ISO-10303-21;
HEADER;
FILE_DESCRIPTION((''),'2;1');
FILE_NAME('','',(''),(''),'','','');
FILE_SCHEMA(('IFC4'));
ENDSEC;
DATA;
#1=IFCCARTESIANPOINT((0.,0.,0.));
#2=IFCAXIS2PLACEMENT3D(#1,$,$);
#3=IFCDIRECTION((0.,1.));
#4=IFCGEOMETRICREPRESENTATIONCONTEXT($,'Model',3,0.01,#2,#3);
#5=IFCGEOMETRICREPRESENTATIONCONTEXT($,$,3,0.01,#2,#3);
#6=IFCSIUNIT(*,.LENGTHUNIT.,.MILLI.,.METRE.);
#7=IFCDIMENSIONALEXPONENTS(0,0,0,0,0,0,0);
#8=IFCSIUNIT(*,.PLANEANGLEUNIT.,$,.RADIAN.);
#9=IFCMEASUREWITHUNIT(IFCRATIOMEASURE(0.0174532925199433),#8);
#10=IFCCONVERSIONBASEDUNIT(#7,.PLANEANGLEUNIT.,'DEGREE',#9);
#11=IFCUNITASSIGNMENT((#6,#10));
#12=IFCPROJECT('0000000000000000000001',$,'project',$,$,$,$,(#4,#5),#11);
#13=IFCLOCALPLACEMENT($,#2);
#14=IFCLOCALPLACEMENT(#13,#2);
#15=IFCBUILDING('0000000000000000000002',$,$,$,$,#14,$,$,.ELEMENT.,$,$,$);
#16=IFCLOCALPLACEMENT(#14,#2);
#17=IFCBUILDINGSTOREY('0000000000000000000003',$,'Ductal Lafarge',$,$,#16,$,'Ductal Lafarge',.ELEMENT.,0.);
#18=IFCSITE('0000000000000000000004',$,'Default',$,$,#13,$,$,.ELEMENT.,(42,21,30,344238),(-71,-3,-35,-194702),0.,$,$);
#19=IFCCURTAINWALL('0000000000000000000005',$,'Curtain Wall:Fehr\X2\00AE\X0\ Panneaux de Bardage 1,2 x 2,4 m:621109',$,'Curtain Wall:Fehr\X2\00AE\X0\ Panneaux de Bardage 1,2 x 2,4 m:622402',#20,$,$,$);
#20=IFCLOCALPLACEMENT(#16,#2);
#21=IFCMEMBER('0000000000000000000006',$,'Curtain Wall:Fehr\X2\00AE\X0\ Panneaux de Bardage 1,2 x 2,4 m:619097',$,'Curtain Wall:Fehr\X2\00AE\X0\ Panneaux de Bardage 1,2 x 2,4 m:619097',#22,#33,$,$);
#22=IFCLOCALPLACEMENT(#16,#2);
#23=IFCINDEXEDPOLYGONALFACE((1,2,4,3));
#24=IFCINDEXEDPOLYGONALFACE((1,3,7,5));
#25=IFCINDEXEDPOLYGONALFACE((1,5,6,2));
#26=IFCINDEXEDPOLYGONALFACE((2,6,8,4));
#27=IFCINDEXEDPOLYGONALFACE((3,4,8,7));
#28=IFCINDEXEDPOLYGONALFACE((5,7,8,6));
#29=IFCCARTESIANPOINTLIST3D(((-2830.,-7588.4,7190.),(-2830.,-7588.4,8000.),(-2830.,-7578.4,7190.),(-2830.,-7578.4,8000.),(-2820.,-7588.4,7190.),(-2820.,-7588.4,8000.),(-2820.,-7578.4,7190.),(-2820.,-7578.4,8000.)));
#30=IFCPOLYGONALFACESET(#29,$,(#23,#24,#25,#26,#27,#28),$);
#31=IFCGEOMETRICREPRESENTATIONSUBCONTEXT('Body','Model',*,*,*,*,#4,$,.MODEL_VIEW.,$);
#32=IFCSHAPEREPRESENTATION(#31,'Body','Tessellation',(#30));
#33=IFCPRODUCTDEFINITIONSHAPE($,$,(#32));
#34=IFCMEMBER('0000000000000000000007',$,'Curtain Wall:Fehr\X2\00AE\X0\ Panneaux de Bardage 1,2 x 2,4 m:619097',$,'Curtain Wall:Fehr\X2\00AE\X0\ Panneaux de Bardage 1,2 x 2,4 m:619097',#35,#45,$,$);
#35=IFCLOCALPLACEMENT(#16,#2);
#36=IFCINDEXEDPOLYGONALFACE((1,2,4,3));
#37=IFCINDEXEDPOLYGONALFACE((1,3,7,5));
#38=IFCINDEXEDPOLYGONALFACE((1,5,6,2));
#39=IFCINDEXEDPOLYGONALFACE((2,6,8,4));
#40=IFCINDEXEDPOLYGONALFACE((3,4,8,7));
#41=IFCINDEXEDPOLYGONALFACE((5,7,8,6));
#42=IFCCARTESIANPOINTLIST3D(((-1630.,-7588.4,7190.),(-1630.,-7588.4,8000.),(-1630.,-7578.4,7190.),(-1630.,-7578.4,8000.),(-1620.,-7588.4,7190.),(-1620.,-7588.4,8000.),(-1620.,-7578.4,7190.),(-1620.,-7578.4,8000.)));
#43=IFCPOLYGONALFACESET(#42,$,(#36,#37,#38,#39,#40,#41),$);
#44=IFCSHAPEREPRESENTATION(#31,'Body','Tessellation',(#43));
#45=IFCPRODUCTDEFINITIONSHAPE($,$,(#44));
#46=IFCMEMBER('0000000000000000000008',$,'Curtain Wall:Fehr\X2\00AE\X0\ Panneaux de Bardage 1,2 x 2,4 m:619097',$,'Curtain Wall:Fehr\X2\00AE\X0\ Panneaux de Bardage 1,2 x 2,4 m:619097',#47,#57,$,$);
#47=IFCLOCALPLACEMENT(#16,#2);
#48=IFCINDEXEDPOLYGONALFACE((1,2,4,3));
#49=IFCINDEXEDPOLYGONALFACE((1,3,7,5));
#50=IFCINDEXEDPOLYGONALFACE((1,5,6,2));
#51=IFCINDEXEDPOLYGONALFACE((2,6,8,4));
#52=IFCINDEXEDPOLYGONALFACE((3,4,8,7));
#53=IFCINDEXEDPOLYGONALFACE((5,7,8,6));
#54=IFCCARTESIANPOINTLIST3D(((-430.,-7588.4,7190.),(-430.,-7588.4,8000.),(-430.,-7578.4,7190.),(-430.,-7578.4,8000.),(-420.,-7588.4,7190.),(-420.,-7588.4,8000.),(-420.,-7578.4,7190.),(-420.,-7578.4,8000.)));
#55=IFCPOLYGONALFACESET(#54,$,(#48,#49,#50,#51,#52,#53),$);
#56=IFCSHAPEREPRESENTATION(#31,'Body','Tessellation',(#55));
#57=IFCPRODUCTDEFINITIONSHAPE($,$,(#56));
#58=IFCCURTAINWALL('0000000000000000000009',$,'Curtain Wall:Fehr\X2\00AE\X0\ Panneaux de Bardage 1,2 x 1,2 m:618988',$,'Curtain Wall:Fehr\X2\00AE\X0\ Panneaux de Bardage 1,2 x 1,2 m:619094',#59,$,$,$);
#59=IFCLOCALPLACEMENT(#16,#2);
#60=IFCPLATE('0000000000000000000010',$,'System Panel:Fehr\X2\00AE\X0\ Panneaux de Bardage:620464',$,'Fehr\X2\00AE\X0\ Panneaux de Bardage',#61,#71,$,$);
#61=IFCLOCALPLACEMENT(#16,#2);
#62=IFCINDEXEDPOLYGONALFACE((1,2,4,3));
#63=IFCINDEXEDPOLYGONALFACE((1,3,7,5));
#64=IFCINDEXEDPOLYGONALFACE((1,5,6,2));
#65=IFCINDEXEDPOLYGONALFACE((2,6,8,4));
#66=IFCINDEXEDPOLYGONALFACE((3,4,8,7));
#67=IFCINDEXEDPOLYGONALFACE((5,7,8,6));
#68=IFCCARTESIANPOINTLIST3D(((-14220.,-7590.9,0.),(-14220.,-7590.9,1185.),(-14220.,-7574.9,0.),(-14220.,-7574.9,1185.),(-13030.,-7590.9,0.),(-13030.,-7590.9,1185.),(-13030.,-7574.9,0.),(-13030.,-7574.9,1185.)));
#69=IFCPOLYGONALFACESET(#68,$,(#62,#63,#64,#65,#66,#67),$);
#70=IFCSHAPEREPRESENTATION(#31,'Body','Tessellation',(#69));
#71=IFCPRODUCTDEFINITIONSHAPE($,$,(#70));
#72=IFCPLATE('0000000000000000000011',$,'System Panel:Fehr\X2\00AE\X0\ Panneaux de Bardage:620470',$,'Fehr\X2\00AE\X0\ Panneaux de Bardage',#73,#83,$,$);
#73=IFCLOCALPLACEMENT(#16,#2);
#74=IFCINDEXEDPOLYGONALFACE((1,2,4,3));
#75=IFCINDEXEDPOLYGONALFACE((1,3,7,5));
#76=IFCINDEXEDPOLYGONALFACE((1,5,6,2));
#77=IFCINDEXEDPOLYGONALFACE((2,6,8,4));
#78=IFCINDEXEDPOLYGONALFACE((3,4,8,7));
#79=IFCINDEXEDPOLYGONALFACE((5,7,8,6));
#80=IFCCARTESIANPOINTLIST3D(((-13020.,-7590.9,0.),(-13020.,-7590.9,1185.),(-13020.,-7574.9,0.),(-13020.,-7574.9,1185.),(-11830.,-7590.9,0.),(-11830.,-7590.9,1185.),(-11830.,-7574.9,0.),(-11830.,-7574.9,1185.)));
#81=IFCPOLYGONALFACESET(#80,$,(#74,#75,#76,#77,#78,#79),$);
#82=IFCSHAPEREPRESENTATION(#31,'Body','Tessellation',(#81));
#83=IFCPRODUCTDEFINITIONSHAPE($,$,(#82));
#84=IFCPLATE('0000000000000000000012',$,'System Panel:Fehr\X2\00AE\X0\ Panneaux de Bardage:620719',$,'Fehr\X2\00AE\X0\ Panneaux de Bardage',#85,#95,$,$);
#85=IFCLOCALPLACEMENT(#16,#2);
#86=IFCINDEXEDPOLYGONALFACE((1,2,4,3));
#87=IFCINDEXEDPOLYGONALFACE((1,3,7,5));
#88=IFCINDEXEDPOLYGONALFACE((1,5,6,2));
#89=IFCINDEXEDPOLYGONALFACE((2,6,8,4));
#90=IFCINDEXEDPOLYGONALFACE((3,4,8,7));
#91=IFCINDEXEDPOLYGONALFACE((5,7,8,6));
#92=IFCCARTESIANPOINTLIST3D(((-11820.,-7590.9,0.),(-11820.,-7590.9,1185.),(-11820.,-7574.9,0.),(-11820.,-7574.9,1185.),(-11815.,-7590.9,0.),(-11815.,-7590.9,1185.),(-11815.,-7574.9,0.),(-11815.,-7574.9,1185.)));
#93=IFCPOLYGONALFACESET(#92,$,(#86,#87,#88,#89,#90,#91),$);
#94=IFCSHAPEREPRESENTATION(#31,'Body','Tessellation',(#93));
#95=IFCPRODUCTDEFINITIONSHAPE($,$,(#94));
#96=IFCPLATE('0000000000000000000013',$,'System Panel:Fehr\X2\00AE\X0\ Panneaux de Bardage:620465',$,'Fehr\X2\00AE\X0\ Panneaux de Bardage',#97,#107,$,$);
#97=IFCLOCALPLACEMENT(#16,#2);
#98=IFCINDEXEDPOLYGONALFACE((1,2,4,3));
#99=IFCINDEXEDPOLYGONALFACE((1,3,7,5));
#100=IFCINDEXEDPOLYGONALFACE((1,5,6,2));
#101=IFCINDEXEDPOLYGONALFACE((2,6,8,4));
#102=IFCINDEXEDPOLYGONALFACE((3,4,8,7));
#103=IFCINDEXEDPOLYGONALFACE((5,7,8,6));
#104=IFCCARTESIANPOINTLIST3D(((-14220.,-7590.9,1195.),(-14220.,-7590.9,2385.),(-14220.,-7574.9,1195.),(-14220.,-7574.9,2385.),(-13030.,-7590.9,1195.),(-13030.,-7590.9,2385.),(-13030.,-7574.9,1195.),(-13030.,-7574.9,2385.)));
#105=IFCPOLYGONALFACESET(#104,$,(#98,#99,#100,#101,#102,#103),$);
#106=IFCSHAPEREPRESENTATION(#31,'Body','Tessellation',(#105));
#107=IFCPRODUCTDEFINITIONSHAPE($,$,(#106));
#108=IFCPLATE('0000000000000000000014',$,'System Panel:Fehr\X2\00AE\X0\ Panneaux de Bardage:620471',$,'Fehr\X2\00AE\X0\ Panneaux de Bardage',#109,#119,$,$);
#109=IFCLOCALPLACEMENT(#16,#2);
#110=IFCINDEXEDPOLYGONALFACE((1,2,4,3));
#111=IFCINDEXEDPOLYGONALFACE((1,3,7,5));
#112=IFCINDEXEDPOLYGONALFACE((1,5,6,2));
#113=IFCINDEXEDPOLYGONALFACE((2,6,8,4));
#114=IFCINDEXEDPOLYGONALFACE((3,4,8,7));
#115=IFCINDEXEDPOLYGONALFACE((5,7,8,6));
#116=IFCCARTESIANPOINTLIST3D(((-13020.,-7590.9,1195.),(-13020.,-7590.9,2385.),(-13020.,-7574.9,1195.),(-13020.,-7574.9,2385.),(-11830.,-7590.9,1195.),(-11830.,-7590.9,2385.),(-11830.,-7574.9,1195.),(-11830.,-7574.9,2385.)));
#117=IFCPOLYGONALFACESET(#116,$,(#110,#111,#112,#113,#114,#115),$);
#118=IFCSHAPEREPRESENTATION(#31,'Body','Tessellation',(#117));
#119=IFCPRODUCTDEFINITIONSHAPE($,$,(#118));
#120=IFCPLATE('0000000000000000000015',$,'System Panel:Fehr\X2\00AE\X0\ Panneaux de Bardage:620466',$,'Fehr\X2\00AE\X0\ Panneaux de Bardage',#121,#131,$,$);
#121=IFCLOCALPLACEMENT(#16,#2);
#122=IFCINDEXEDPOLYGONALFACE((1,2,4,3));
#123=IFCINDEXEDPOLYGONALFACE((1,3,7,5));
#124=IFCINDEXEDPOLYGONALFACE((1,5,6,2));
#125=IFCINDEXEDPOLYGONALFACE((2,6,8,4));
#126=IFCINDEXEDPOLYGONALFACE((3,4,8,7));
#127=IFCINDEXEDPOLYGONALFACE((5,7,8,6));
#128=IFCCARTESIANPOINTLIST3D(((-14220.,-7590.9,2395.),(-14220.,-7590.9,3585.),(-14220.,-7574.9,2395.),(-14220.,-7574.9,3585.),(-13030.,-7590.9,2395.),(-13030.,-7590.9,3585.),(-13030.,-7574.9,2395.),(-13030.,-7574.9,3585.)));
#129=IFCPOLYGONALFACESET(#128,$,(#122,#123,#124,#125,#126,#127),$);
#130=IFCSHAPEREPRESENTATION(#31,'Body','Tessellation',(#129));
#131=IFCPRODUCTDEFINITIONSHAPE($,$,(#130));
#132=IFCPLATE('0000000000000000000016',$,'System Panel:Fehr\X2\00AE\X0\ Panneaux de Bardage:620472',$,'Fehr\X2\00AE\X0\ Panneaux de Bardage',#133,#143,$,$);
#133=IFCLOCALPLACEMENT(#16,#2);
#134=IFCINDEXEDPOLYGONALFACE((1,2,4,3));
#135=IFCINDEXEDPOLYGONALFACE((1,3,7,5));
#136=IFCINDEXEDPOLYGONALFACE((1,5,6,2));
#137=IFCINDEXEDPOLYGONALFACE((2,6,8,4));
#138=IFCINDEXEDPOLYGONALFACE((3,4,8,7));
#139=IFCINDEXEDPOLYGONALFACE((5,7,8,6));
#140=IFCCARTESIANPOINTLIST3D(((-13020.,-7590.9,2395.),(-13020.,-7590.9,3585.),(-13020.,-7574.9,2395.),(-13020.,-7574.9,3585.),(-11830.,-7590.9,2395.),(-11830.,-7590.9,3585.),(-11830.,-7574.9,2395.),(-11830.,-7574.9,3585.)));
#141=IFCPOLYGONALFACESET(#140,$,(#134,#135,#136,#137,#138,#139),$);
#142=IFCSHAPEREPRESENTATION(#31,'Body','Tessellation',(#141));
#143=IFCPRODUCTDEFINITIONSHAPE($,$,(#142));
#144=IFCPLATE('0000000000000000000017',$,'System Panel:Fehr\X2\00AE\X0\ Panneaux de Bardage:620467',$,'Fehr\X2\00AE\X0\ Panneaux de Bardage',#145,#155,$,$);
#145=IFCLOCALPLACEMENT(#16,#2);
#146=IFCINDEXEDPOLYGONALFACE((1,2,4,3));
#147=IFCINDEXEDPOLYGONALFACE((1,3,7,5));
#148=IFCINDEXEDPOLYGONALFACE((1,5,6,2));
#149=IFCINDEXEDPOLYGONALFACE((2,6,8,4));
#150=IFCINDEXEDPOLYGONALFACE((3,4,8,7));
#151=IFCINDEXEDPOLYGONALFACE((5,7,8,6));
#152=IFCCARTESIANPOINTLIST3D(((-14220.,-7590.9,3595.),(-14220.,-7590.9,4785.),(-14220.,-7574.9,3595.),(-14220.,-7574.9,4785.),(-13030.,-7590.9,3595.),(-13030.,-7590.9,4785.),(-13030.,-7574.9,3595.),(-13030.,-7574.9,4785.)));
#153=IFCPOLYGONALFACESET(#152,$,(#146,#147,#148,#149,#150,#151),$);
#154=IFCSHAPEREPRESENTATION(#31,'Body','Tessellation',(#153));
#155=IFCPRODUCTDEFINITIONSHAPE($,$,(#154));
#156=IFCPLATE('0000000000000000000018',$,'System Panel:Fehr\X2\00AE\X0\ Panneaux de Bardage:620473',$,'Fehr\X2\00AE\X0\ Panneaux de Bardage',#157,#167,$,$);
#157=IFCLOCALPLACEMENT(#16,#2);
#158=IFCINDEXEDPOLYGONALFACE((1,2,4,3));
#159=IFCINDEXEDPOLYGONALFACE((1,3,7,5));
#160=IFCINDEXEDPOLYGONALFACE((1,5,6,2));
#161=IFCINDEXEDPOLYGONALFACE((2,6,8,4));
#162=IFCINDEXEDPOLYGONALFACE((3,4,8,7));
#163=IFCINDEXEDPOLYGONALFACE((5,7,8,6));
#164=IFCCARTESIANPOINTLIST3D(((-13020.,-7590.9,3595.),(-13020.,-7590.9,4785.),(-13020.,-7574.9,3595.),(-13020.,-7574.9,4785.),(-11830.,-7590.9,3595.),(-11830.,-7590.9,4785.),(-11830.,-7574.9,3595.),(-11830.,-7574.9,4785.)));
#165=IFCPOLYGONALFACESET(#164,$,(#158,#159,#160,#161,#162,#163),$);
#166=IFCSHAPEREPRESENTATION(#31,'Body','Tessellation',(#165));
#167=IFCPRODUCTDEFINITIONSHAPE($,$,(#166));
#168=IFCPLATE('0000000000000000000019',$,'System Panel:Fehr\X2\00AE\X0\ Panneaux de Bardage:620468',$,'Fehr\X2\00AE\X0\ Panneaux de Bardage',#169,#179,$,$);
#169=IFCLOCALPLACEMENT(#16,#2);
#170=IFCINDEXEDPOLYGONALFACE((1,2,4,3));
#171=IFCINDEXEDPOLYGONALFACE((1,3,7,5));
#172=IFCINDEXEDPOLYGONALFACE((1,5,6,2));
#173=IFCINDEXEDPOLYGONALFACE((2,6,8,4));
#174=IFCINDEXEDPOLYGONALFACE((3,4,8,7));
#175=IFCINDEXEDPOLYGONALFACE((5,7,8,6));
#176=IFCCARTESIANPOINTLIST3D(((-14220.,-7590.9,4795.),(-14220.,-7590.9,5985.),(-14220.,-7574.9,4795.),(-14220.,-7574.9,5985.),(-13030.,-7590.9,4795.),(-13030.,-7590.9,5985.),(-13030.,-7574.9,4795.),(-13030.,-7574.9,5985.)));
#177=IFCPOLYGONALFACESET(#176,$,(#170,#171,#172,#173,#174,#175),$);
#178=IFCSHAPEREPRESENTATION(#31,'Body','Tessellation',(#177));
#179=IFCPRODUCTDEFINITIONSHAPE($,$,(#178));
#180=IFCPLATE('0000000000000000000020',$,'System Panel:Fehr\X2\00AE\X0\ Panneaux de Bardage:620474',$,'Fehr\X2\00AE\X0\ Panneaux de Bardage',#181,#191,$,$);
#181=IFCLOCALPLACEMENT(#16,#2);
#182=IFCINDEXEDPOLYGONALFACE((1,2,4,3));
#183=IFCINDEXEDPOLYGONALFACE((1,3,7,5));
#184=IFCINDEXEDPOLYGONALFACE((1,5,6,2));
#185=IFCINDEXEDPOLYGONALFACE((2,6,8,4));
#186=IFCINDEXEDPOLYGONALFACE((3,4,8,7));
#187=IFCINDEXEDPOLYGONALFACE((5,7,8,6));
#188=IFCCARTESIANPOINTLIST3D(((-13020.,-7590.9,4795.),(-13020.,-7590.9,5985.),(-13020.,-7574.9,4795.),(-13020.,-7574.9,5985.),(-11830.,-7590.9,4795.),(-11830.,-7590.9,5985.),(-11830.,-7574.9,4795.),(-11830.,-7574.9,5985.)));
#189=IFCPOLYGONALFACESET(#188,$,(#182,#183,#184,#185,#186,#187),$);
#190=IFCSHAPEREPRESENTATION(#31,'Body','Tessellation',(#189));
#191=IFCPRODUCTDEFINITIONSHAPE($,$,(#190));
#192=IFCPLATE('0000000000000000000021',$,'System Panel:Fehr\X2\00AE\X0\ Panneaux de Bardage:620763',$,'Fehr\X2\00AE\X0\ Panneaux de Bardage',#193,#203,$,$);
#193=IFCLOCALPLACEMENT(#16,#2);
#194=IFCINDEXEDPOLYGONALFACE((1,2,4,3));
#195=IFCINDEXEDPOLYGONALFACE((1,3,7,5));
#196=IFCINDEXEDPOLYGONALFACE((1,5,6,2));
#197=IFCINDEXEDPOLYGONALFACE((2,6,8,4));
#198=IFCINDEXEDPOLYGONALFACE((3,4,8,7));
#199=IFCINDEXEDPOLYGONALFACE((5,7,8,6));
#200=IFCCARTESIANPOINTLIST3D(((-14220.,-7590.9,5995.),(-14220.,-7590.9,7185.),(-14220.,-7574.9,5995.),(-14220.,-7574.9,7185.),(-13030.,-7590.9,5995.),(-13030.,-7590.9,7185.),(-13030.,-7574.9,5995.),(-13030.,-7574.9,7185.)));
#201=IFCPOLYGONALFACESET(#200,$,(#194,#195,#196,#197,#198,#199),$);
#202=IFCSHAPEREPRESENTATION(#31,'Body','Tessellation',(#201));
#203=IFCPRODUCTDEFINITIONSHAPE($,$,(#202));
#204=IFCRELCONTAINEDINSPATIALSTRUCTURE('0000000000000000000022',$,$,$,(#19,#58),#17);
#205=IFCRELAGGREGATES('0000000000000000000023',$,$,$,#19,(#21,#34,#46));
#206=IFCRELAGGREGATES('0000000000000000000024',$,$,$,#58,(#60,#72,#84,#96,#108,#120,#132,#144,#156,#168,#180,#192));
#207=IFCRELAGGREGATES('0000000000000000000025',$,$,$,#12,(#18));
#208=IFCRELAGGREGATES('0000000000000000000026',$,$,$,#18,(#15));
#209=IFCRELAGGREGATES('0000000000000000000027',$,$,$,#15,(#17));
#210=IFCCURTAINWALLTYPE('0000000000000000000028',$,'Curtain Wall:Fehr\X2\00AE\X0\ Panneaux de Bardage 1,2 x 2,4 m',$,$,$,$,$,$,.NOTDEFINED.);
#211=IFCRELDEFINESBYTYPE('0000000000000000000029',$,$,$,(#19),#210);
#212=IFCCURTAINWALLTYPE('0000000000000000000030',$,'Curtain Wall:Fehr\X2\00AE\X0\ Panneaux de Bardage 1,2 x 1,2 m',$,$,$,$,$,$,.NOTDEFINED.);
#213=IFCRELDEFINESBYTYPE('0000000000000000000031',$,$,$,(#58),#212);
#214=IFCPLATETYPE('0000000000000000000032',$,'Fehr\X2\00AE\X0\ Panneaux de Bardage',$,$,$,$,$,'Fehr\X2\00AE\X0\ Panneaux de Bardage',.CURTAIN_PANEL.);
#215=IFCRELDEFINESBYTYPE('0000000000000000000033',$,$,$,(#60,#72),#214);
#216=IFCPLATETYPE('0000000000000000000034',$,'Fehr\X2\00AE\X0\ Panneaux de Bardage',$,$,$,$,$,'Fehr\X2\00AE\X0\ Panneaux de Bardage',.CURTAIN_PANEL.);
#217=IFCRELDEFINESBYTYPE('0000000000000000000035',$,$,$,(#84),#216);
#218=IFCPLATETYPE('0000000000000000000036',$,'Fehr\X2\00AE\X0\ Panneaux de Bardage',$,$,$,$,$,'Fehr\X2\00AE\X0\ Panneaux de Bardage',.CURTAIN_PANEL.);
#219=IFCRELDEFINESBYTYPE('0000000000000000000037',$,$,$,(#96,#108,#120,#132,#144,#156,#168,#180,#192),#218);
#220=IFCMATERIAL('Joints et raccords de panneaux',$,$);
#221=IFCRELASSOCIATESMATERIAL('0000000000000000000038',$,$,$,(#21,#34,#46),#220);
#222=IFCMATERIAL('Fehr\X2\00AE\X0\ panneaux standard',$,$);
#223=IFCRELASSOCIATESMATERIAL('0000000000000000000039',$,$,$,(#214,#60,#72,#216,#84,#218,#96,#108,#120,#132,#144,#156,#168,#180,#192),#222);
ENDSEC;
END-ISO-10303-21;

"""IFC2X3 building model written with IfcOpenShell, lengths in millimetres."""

from ifc_helpers import new_model, entity, si_unit, converted_unit, direction, frame, frame_2d, origin, origin_2d_with_axis, place, context, subcontext, project, spatial, rectangle, extrude, source, transform, mapped, material, type_object, type_shapes, element, aggregate, save


model = new_model("IFC2X3")

# Units and contexts
model_context = context("Model", 3, precision=0.01, world=origin(), true_north=direction((0.0, 1.0)))
context_of_model = context(None, 3, precision=0.01, world=origin(), true_north=direction((0.0, 1.0)))
body_context = subcontext(model_context, "Body", "Model", "MODEL_VIEW")
ifc_project = project(units=[si_unit("LENGTHUNIT", "METRE", prefix="MILLI"), converted_unit("PLANEANGLEUNIT", "DEGREE", entity("IfcRatioMeasure", 0.0174532925199433), si_unit("PLANEANGLEUNIT", "RADIAN"), dimensions=[0, 0, 0, 0, 0, 0, 0])], contexts=[model_context, context_of_model])

# Site, building, storey
site_placement = place(None, origin())
site = spatial("IfcSite", under=ifc_project, at=site_placement, Name="Default", CompositionType="ELEMENT", RefLatitude=(42, 21, 30, 344238), RefLongitude=(-71, -3, -35, -194702), RefElevation=0.0)
building_placement = place(site_placement, origin())
building = spatial("IfcBuilding", under=site, at=building_placement, CompositionType="ELEMENT")
storey_placement = place(building_placement, origin())
storey = spatial("IfcBuildingStorey", under=building, at=storey_placement, Name="Ductal Lafarge", LongName="Ductal Lafarge", CompositionType="ELEMENT", Elevation=0.0)

# Curtain wall, members
curtain_wall_type_1 = type_object("IfcCurtainWallType", Name="Curtain Wall:Fehr® Panneaux de Bardage 1,2 x 2,4 m", PredefinedType="NOTDEFINED")
curtain_wall_1_placement = place(storey_placement, origin())
curtain_wall_1 = element("IfcCurtainWall", 1, at=curtain_wall_1_placement, inside=storey, type_object=curtain_wall_type_1, Name="Curtain Wall:Fehr® Panneaux de Bardage 1,2 x 2,4 m:621109", ObjectType="Curtain Wall:Fehr® Panneaux de Bardage 1,2 x 2,4 m:622402")
ifc_material_1 = material(Name="Joints et raccords de panneaux")
member_1_placement = place(curtain_wall_1_placement, frame((-2830.0, -7588.4, 7190.0)))
member_1 = element("IfcMember", 2, at=member_1_placement, material=ifc_material_1, Name="Curtain Wall:Fehr® Panneaux de Bardage 1,2 x 2,4 m:619097", ObjectType="Curtain Wall:Fehr® Panneaux de Bardage 1,2 x 2,4 m:619097", context=body_context, shape_type="SweptSolid", body=[
    extrude(rectangle(XDim=10.0, YDim=10.0, at=origin_2d_with_axis()), frame((5.0, 5.0, 0.0), z_axis=(0.0, 0.0, 1.0), x_axis=(0.0, 1.0, 0.0)), (0.0, 0.0, 1.0), 810.0),
])
member_2_placement = place(curtain_wall_1_placement, frame((-1630.0, -7588.4, 7190.0)))
member_2 = element("IfcMember", 3, at=member_2_placement, material=ifc_material_1, Name="Curtain Wall:Fehr® Panneaux de Bardage 1,2 x 2,4 m:619097", ObjectType="Curtain Wall:Fehr® Panneaux de Bardage 1,2 x 2,4 m:619097", context=body_context, shape_type="SweptSolid", body=[
    extrude(rectangle(XDim=10.0, YDim=10.0, at=origin_2d_with_axis()), frame((5.0, 5.0, 0.0), z_axis=(0.0, 0.0, 1.0), x_axis=(0.0, 1.0, 0.0)), (0.0, 0.0, 1.0), 810.0),
])
member_3_placement = place(curtain_wall_1_placement, frame((-430.0, -7588.4, 7190.0)))
member_3 = element("IfcMember", 4, at=member_3_placement, material=ifc_material_1, Name="Curtain Wall:Fehr® Panneaux de Bardage 1,2 x 2,4 m:619097", ObjectType="Curtain Wall:Fehr® Panneaux de Bardage 1,2 x 2,4 m:619097", context=body_context, shape_type="SweptSolid", body=[
    extrude(rectangle(XDim=10.0, YDim=10.0, at=frame_2d((0.0, 0.0), x_axis=(1.0, 0.0))), frame((5.0, 5.0, 0.0), z_axis=(0.0, 0.0, 1.0), x_axis=(0.0, 1.0, 0.0)), (0.0, 0.0, 1.0), 810.0),
])
aggregate(curtain_wall_1, [member_1, member_2, member_3])

# Curtain wall, plates
curtain_wall_type_2 = type_object("IfcCurtainWallType", Name="Curtain Wall:Fehr® Panneaux de Bardage 1,2 x 1,2 m", PredefinedType="NOTDEFINED")
curtain_wall_2_placement = place(storey_placement, origin())
curtain_wall_2 = element("IfcCurtainWall", 5, at=curtain_wall_2_placement, inside=storey, type_object=curtain_wall_type_2, Name="Curtain Wall:Fehr® Panneaux de Bardage 1,2 x 1,2 m:618988", ObjectType="Curtain Wall:Fehr® Panneaux de Bardage 1,2 x 1,2 m:619094")
ifc_material_2 = material(Name="Fehr® panneaux standard")
plate_type_1 = type_object("IfcPlateType", Name="Fehr® Panneaux de Bardage", ElementType="Fehr® Panneaux de Bardage", PredefinedType="CURTAIN_PANEL", material=ifc_material_2)
shared_shape_1 = source(origin(), body_context, "Body", "SweptSolid", [
    extrude(rectangle(XDim=16.0, YDim=1190.0, at=origin_2d_with_axis()), frame((0.0, 0.0, 0.0), z_axis=(0.0, 0.0, 1.0), x_axis=(0.0, 1.0, 0.0)), (0.0, 0.0, 1.0), 1185.0),
])
type_shapes(plate_type_1, [shared_shape_1])
plate_1_placement = place(curtain_wall_2_placement, frame((-13625.0, -7582.9, 0.0)))
plate_1 = element("IfcPlate", 6, at=plate_1_placement, type_object=plate_type_1, material=ifc_material_2, Name="System Panel:Fehr® Panneaux de Bardage:620464", ObjectType="Fehr® Panneaux de Bardage", context=body_context, shape_type="MappedRepresentation", body=[
    mapped(shared_shape_1, transform((0.0, 0.0, 0.0), scale=1.0)),
])
plate_2_placement = place(curtain_wall_2_placement, frame((-12425.0, -7582.9, 0.0)))
plate_2 = element("IfcPlate", 7, at=plate_2_placement, type_object=plate_type_1, material=ifc_material_2, Name="System Panel:Fehr® Panneaux de Bardage:620470", ObjectType="Fehr® Panneaux de Bardage", context=body_context, shape_type="MappedRepresentation", body=[
    mapped(shared_shape_1, transform((0.0, 0.0, 0.0), scale=1.0)),
])
plate_type_2 = type_object("IfcPlateType", Name="Fehr® Panneaux de Bardage", ElementType="Fehr® Panneaux de Bardage", PredefinedType="CURTAIN_PANEL", material=ifc_material_2)
shared_shape_2 = source(origin(), body_context, "Body", "SweptSolid", [
    extrude(rectangle(XDim=16.0, YDim=5.0, at=origin_2d_with_axis()), frame((0.0, 0.0, 0.0), z_axis=(0.0, 0.0, 1.0), x_axis=(0.0, 1.0, 0.0)), (0.0, 0.0, 1.0), 1185.0),
])
type_shapes(plate_type_2, [shared_shape_2])
plate_3_placement = place(curtain_wall_2_placement, frame((-11817.5, -7582.9, 0.0)))
plate_3 = element("IfcPlate", 8, at=plate_3_placement, type_object=plate_type_2, material=ifc_material_2, Name="System Panel:Fehr® Panneaux de Bardage:620719", ObjectType="Fehr® Panneaux de Bardage", context=body_context, shape_type="MappedRepresentation", body=[
    mapped(shared_shape_2, transform((0.0, 0.0, 0.0), scale=1.0)),
])
plate_type_3 = type_object("IfcPlateType", Name="Fehr® Panneaux de Bardage", ElementType="Fehr® Panneaux de Bardage", PredefinedType="CURTAIN_PANEL", material=ifc_material_2)
shared_shape_3 = source(origin(), body_context, "Body", "SweptSolid", [
    extrude(rectangle(XDim=16.0, YDim=1190.0, at=origin_2d_with_axis()), frame((0.0, 0.0, 0.0), z_axis=(0.0, 0.0, 1.0), x_axis=(0.0, 1.0, 0.0)), (0.0, 0.0, 1.0), 1190.0),
])
type_shapes(plate_type_3, [shared_shape_3])
plate_4_placement = place(curtain_wall_2_placement, frame((-13625.0, -7582.9, 1195.0)))
plate_4 = element("IfcPlate", 9, at=plate_4_placement, type_object=plate_type_3, material=ifc_material_2, Name="System Panel:Fehr® Panneaux de Bardage:620465", ObjectType="Fehr® Panneaux de Bardage", context=body_context, shape_type="MappedRepresentation", body=[
    mapped(shared_shape_3, transform((0.0, 0.0, 0.0), scale=1.0)),
])
plate_5_placement = place(curtain_wall_2_placement, frame((-12425.0, -7582.9, 1195.0)))
plate_5 = element("IfcPlate", 10, at=plate_5_placement, type_object=plate_type_3, material=ifc_material_2, Name="System Panel:Fehr® Panneaux de Bardage:620471", ObjectType="Fehr® Panneaux de Bardage", context=body_context, shape_type="MappedRepresentation", body=[
    mapped(shared_shape_3, transform((0.0, 0.0, 0.0), scale=1.0)),
])
plate_6_placement = place(curtain_wall_2_placement, frame((-13625.0, -7582.9, 2395.0)))
plate_6 = element("IfcPlate", 11, at=plate_6_placement, type_object=plate_type_3, material=ifc_material_2, Name="System Panel:Fehr® Panneaux de Bardage:620466", ObjectType="Fehr® Panneaux de Bardage", context=body_context, shape_type="MappedRepresentation", body=[
    mapped(shared_shape_3, transform((0.0, 0.0, 0.0), scale=1.0)),
])
plate_7_placement = place(curtain_wall_2_placement, frame((-12425.0, -7582.9, 2395.0)))
plate_7 = element("IfcPlate", 12, at=plate_7_placement, type_object=plate_type_3, material=ifc_material_2, Name="System Panel:Fehr® Panneaux de Bardage:620472", ObjectType="Fehr® Panneaux de Bardage", context=body_context, shape_type="MappedRepresentation", body=[
    mapped(shared_shape_3, transform((0.0, 0.0, 0.0), scale=1.0)),
])
plate_8_placement = place(curtain_wall_2_placement, frame((-13625.0, -7582.9, 3595.0)))
plate_8 = element("IfcPlate", 13, at=plate_8_placement, type_object=plate_type_3, material=ifc_material_2, Name="System Panel:Fehr® Panneaux de Bardage:620467", ObjectType="Fehr® Panneaux de Bardage", context=body_context, shape_type="MappedRepresentation", body=[
    mapped(shared_shape_3, transform((0.0, 0.0, 0.0), scale=1.0)),
])
plate_9_placement = place(curtain_wall_2_placement, frame((-12425.0, -7582.9, 3595.0)))
plate_9 = element("IfcPlate", 14, at=plate_9_placement, type_object=plate_type_3, material=ifc_material_2, Name="System Panel:Fehr® Panneaux de Bardage:620473", ObjectType="Fehr® Panneaux de Bardage", context=body_context, shape_type="MappedRepresentation", body=[
    mapped(shared_shape_3, transform((0.0, 0.0, 0.0), scale=1.0)),
])
plate_10_placement = place(curtain_wall_2_placement, frame((-13625.0, -7582.9, 4795.0)))
plate_10 = element("IfcPlate", 15, at=plate_10_placement, type_object=plate_type_3, material=ifc_material_2, Name="System Panel:Fehr® Panneaux de Bardage:620468", ObjectType="Fehr® Panneaux de Bardage", context=body_context, shape_type="MappedRepresentation", body=[
    mapped(shared_shape_3, transform((0.0, 0.0, 0.0), scale=1.0)),
])
plate_11_placement = place(curtain_wall_2_placement, frame((-12425.0, -7582.9, 4795.0)))
plate_11 = element("IfcPlate", 16, at=plate_11_placement, type_object=plate_type_3, material=ifc_material_2, Name="System Panel:Fehr® Panneaux de Bardage:620474", ObjectType="Fehr® Panneaux de Bardage", context=body_context, shape_type="MappedRepresentation", body=[
    mapped(shared_shape_3, transform((0.0, 0.0, 0.0), scale=1.0)),
])
plate_12_placement = place(curtain_wall_2_placement, frame((-13625.0, -7582.9, 5995.0)))
plate_12 = element("IfcPlate", 17, at=plate_12_placement, type_object=plate_type_3, material=ifc_material_2, Name="System Panel:Fehr® Panneaux de Bardage:620763", ObjectType="Fehr® Panneaux de Bardage", context=body_context, shape_type="MappedRepresentation", body=[
    mapped(shared_shape_3, transform((0.0, 0.0, 0.0), scale=1.0)),
])
aggregate(curtain_wall_2, [plate_1, plate_2, plate_3, plate_4, plate_5, plate_6, plate_7, plate_8, plate_9, plate_10, plate_11, plate_12])

save(model, "model.ifc")
